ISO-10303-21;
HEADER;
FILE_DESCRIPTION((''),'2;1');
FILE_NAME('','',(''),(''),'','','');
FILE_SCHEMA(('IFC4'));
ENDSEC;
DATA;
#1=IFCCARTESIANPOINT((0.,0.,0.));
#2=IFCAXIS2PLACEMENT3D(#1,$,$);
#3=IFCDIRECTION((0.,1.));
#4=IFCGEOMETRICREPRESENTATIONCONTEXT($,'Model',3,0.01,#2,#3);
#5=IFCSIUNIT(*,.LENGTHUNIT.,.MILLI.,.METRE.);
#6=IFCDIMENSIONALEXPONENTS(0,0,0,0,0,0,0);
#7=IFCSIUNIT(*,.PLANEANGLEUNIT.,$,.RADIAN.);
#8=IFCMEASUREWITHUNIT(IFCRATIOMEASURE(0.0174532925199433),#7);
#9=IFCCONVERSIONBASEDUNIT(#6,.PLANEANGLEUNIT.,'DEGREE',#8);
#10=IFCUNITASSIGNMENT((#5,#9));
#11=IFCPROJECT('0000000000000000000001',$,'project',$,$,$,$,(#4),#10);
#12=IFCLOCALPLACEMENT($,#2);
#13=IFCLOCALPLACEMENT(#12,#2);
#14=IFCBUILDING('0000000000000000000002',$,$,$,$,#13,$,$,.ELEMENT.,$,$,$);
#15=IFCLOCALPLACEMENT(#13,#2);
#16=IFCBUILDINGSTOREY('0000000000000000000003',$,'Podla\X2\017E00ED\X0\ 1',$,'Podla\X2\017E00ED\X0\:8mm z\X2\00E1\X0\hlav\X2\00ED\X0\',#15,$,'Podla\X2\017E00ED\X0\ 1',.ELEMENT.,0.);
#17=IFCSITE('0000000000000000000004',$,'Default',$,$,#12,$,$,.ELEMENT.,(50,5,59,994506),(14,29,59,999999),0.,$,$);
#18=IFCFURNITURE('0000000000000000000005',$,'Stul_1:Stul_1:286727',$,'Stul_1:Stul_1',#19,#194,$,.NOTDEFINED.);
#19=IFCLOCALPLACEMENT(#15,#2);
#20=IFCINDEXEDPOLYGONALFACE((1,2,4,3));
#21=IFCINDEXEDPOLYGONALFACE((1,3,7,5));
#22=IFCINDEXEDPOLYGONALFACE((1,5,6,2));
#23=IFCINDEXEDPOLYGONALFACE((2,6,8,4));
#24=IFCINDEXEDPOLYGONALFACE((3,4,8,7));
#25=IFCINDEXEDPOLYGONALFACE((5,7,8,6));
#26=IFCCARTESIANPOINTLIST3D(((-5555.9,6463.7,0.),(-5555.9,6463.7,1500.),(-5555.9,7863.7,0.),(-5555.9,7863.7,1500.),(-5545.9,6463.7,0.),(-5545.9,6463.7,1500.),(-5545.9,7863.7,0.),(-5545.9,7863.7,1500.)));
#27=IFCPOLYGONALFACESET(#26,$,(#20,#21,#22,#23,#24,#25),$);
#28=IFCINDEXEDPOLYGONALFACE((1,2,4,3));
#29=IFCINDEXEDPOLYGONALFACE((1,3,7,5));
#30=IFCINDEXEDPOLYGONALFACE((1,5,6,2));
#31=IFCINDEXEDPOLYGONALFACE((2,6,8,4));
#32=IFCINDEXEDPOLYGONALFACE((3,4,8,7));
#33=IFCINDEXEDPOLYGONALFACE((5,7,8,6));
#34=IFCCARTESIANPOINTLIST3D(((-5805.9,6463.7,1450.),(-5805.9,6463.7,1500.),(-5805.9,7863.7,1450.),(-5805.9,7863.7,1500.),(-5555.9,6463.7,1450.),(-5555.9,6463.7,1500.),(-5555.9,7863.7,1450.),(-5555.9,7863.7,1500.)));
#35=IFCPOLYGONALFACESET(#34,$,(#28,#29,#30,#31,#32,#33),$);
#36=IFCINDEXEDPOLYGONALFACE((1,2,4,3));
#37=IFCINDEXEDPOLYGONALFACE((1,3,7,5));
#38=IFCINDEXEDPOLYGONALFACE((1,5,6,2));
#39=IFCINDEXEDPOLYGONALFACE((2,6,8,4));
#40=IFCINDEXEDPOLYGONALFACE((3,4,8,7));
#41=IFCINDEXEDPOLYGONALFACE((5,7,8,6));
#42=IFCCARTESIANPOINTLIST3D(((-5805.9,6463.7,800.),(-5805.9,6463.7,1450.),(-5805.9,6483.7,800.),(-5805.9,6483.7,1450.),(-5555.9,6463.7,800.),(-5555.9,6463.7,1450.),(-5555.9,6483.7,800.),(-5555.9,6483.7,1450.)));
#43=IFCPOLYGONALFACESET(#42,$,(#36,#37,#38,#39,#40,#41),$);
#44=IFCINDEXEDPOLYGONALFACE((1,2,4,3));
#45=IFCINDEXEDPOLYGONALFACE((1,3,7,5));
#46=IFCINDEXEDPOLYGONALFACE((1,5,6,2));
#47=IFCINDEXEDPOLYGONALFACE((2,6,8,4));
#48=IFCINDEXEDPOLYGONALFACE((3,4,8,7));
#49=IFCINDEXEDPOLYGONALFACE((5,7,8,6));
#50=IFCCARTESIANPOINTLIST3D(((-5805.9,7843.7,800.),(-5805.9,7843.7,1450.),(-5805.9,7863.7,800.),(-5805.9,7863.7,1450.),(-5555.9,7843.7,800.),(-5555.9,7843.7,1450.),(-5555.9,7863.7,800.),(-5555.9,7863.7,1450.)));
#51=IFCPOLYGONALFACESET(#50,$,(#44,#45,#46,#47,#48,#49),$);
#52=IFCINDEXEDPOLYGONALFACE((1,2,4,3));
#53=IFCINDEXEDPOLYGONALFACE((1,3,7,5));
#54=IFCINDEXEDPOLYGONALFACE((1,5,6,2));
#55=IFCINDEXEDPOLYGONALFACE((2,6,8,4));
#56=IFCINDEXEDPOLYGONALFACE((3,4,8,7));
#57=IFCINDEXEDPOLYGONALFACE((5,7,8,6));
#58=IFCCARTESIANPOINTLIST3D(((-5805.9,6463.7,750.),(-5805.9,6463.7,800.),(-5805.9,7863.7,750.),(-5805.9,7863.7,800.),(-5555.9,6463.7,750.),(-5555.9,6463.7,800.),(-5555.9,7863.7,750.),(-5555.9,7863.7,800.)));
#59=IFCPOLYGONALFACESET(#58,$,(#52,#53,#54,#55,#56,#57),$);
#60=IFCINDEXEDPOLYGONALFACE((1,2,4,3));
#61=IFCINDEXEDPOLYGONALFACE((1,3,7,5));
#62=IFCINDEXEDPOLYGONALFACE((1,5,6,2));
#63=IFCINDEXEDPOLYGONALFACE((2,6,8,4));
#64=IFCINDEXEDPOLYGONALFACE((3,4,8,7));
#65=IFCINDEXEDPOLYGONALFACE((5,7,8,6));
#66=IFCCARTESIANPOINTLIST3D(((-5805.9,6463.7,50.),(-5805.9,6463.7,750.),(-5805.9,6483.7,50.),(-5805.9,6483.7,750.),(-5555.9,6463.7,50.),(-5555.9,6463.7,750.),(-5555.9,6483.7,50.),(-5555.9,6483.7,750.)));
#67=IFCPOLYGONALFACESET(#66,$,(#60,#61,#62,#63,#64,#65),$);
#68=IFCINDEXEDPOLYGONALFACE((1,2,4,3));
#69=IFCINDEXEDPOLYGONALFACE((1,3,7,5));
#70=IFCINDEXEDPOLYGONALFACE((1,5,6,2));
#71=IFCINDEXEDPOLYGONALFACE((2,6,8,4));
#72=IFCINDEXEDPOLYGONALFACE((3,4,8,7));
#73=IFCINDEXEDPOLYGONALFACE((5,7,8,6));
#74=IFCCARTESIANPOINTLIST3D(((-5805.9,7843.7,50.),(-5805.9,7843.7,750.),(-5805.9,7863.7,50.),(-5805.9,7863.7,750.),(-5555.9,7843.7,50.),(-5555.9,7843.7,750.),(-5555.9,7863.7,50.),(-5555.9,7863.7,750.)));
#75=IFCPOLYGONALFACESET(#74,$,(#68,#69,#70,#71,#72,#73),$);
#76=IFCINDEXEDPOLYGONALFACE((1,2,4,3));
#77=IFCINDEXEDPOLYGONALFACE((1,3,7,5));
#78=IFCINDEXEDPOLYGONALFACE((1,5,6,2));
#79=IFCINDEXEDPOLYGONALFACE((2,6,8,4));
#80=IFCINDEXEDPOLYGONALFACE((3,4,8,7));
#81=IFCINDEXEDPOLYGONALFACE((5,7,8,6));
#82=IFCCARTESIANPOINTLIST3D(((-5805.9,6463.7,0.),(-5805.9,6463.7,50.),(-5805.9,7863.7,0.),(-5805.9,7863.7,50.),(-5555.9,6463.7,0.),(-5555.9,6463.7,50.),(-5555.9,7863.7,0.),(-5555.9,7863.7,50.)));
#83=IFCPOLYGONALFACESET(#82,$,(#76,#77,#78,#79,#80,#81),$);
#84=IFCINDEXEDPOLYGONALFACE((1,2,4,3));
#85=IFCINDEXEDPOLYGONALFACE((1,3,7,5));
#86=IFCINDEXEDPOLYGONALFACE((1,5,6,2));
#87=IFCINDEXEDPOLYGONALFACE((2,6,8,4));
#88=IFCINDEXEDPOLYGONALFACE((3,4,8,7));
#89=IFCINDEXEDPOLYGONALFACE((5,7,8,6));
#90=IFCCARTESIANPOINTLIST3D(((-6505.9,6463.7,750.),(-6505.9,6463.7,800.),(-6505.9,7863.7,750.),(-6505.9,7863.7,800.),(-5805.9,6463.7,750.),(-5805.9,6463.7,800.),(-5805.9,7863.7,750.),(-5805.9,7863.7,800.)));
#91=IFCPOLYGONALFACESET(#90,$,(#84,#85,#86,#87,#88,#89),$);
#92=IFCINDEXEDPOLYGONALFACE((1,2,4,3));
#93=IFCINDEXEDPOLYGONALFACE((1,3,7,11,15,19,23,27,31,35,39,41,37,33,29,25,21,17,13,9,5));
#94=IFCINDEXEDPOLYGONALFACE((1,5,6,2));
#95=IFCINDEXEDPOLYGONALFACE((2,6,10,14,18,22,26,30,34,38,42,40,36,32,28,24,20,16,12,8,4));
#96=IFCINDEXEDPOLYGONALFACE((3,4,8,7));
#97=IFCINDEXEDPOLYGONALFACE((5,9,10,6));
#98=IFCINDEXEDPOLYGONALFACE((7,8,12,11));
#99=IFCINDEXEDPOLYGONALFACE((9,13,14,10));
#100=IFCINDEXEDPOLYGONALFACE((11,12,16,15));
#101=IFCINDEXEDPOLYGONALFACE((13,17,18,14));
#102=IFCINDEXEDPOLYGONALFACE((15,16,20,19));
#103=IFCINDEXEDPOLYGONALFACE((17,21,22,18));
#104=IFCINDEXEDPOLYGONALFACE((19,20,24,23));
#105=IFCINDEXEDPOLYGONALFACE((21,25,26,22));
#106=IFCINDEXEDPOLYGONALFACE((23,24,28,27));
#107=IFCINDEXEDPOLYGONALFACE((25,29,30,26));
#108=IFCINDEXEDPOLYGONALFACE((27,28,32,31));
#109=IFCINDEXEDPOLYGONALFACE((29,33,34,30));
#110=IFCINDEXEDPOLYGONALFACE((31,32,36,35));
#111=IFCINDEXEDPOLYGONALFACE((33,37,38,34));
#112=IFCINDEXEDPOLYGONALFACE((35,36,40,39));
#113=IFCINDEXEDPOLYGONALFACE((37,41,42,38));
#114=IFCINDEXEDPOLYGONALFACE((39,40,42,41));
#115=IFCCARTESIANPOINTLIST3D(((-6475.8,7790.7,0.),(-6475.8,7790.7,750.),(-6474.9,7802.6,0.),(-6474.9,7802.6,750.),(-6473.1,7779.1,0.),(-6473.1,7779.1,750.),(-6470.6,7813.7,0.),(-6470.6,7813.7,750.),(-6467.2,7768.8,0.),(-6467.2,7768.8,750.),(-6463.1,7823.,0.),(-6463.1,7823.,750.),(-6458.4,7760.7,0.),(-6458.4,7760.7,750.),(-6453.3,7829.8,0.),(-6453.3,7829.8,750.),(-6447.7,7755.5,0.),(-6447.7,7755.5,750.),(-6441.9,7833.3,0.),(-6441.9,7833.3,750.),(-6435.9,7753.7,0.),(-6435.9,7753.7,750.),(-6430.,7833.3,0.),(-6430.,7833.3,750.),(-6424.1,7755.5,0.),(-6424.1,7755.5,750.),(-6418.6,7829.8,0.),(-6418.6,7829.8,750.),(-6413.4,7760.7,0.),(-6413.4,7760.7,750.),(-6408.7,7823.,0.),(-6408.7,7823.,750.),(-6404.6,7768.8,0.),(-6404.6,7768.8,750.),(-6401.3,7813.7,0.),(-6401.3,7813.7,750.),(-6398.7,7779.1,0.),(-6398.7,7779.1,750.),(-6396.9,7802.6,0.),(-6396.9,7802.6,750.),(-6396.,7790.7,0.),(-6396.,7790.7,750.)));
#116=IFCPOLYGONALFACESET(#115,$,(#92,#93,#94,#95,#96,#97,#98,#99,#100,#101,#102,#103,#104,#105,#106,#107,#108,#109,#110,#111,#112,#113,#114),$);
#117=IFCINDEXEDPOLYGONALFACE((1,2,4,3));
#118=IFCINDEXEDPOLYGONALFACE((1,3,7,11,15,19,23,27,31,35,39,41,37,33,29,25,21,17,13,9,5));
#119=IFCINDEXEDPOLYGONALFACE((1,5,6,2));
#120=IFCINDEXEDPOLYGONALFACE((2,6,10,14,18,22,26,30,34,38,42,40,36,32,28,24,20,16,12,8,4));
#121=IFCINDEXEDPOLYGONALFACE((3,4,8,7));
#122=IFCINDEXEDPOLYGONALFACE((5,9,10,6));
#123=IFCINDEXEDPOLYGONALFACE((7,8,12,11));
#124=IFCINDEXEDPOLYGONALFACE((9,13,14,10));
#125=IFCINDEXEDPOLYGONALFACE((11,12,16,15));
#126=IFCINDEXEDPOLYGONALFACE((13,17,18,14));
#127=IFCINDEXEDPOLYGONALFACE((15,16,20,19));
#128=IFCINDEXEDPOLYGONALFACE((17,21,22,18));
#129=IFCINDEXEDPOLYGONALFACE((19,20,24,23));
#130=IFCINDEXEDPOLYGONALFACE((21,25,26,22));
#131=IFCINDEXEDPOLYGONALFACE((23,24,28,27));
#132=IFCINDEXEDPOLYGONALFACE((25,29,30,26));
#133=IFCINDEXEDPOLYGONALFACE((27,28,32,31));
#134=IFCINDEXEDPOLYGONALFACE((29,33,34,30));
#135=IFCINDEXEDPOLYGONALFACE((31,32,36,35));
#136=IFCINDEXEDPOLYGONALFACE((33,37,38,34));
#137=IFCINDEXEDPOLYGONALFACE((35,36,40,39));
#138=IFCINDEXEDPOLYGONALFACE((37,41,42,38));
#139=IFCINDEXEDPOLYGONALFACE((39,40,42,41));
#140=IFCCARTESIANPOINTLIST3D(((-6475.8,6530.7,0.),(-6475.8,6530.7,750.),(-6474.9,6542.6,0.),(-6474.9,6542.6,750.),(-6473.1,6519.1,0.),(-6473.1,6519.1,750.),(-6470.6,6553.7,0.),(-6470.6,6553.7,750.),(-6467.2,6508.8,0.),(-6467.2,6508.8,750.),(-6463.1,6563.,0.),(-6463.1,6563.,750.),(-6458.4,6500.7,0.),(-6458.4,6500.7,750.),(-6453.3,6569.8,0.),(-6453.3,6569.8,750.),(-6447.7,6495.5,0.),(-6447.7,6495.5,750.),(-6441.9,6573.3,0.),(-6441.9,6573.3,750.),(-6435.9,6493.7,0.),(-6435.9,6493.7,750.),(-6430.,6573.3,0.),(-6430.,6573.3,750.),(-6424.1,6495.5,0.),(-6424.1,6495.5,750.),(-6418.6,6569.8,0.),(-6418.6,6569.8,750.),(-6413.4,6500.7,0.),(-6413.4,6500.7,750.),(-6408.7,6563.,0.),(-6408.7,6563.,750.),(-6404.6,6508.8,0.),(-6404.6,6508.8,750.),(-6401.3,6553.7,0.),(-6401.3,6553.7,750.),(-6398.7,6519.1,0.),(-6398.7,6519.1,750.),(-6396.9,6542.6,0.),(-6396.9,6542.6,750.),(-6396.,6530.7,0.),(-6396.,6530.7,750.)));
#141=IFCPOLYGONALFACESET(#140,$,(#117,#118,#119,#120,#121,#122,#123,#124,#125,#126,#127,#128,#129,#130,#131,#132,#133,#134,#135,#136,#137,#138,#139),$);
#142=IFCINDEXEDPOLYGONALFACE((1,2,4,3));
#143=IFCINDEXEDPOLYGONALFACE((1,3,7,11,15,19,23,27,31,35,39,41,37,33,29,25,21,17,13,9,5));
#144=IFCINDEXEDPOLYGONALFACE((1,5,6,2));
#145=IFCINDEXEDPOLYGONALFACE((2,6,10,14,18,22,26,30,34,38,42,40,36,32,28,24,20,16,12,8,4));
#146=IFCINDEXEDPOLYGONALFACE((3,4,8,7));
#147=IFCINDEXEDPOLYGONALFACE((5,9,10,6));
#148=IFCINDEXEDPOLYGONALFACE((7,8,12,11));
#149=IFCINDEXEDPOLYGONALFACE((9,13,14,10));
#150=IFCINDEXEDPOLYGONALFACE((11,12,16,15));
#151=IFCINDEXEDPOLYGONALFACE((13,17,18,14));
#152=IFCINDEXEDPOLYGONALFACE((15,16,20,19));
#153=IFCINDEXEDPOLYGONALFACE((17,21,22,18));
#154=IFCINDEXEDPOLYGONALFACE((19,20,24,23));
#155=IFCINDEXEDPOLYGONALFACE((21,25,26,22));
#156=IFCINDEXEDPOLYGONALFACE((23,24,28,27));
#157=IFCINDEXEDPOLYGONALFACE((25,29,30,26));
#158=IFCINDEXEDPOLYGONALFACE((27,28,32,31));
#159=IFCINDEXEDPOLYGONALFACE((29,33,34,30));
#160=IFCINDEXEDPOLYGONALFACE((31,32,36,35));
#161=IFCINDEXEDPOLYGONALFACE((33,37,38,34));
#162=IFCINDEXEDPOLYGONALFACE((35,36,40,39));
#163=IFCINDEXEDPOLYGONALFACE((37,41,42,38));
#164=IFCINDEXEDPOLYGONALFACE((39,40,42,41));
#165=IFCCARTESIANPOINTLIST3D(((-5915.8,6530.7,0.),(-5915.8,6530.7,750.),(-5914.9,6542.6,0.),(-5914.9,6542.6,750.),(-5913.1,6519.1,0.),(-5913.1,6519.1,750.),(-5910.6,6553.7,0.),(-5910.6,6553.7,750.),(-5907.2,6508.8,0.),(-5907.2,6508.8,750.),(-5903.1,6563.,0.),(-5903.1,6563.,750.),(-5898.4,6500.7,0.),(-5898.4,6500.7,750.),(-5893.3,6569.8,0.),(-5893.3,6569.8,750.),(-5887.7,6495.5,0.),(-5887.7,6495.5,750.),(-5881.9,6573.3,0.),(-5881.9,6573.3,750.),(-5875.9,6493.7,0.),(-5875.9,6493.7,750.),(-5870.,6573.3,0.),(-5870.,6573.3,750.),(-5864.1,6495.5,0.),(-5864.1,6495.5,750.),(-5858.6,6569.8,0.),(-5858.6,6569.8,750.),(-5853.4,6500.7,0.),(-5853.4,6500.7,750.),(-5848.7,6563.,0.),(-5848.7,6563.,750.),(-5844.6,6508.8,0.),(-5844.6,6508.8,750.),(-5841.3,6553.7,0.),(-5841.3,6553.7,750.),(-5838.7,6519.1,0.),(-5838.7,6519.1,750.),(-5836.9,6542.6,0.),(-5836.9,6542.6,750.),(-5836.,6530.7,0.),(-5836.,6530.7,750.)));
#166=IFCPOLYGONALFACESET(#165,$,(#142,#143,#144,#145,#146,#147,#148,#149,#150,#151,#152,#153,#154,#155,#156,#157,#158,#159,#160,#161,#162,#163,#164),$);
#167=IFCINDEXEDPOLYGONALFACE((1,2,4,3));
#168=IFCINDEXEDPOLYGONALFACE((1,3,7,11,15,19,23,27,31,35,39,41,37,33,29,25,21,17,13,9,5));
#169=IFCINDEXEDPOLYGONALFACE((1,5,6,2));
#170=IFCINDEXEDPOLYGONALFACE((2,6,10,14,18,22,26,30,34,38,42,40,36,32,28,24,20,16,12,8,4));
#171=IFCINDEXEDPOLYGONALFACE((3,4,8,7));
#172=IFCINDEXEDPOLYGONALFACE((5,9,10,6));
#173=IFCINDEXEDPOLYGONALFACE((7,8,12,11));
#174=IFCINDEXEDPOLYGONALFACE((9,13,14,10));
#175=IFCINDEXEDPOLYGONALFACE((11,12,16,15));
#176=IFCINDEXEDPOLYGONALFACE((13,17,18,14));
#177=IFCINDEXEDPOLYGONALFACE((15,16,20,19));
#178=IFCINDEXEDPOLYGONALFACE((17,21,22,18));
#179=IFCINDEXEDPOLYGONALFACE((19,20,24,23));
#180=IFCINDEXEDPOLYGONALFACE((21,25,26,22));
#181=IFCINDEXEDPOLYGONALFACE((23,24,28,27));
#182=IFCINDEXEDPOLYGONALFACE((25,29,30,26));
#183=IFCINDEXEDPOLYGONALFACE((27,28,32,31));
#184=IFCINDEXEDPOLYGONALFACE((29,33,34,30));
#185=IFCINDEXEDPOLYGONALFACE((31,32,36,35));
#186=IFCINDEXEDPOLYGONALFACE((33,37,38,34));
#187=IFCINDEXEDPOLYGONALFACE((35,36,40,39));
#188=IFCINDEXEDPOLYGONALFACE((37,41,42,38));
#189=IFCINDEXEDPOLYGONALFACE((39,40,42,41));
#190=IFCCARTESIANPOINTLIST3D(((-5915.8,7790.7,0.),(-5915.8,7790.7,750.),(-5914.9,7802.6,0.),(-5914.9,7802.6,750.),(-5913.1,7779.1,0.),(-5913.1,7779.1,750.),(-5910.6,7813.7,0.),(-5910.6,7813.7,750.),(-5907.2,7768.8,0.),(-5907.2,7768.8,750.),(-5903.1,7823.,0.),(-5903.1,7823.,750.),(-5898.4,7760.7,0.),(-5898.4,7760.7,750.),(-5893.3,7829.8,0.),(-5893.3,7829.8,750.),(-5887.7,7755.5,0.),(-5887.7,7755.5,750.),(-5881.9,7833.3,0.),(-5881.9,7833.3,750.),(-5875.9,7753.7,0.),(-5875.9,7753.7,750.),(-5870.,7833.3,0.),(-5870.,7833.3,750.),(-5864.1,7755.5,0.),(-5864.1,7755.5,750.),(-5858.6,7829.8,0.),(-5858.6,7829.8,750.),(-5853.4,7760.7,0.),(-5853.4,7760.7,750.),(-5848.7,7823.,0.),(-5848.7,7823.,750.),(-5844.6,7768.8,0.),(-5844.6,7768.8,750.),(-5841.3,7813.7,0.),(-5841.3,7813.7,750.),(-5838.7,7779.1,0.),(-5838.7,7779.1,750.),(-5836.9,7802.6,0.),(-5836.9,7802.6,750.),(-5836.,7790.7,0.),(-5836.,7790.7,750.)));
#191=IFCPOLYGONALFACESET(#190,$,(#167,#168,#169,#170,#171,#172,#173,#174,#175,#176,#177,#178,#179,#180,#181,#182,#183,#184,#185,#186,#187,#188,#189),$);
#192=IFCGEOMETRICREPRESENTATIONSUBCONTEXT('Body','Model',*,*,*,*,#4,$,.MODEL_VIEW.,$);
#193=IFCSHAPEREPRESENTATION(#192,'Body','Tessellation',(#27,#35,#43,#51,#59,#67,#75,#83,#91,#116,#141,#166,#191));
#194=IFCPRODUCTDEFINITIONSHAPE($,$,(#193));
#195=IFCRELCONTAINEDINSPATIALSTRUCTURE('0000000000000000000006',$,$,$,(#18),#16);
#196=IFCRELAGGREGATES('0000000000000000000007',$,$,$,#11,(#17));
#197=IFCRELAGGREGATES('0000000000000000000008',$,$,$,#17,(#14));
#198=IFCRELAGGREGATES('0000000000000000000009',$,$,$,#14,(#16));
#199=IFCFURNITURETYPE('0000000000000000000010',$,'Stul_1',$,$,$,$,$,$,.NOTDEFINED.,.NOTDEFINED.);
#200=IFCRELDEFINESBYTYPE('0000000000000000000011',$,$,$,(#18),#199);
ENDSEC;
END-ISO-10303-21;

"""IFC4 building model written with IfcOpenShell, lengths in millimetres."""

from ifc_helpers import new_model, entity, si_unit, converted_unit, direction, frame, frame_2d, origin, origin_2d_with_axis, place, context, subcontext, project, spatial, rectangle, circle, extrude, source, transform, mapped, type_object, type_shapes, element, save


model = new_model("IFC4")

# Units and contexts
model_context = context("Model", 3, precision=0.01, world=origin(), true_north=direction((0.0, 1.0)))
body_context = subcontext(model_context, "Body", "Model", "MODEL_VIEW")
ifc_project = project(units=[si_unit("LENGTHUNIT", "METRE", prefix="MILLI"), converted_unit("PLANEANGLEUNIT", "DEGREE", entity("IfcRatioMeasure", 0.0174532925199433), si_unit("PLANEANGLEUNIT", "RADIAN"), dimensions=[0, 0, 0, 0, 0, 0, 0])], contexts=[model_context])

# Site, building, storey
site_placement = place(None, origin())
site = spatial("IfcSite", under=ifc_project, at=site_placement, Name="Default", CompositionType="ELEMENT", RefLatitude=(50, 5, 59, 994506), RefLongitude=(14, 29, 59, 999999), RefElevation=0.0)
building_placement = place(site_placement, origin())
building = spatial("IfcBuilding", under=site, at=building_placement, CompositionType="ELEMENT")
storey_placement = place(building_placement, origin())
storey = spatial("IfcBuildingStorey", under=building, at=storey_placement, Name="Podlaží 1", ObjectType="Podlaží:8mm záhlaví", LongName="Podlaží 1", CompositionType="ELEMENT", Elevation=0.0)

# Furniture
furniture_type = type_object("IfcFurnitureType", Name="Stul_1", AssemblyPlace="NOTDEFINED", PredefinedType="NOTDEFINED")
shared_shape_1 = source(origin(), body_context, "Body", "SweptSolid", [
    extrude(rectangle(XDim=1400.0, YDim=10.0, at=origin_2d_with_axis()), frame((0.0, 605.0, 0.0), z_axis=(0.0, 0.0, 1.0), x_axis=(-1.0, 0.0, 0.0)), (0.0, 0.0, 1.0), 1500.0),
    extrude(rectangle(XDim=1400.0, YDim=250.0, at=frame_2d((0.0, 0.0), x_axis=(1.0, 0.0))), frame((0.0, 475.0, 1450.0), z_axis=(0.0, 0.0, 1.0), x_axis=(-1.0, 0.0, 0.0)), (0.0, 0.0, 1.0), 50.0),
    extrude(rectangle(XDim=20.0, YDim=250.0, at=origin_2d_with_axis()), frame((690.0, 475.0, 800.0), z_axis=(0.0, 0.0, 1.0), x_axis=(-1.0, 0.0, 0.0)), (0.0, 0.0, 1.0), 650.0),
    extrude(rectangle(XDim=20.0, YDim=250.0, at=frame_2d((0.0, 0.0), x_axis=(1.0, 0.0))), frame((-690.0, 475.0, 800.0), z_axis=(0.0, 0.0, 1.0), x_axis=(-1.0, 0.0, 0.0)), (0.0, 0.0, 1.0), 650.0),
    extrude(rectangle(XDim=1400.0, YDim=250.0, at=origin_2d_with_axis()), frame((0.0, 475.0, 750.0), z_axis=(0.0, 0.0, 1.0), x_axis=(-1.0, 0.0, 0.0)), (0.0, 0.0, 1.0), 50.0),
    extrude(rectangle(XDim=20.0, YDim=250.0, at=origin_2d_with_axis()), frame((690.0, 475.0, 50.0), z_axis=(0.0, 0.0, 1.0), x_axis=(-1.0, 0.0, 0.0)), (0.0, 0.0, 1.0), 700.0),
    extrude(rectangle(XDim=20.0, YDim=250.0, at=frame_2d((0.0, 0.0), x_axis=(1.0, 0.0))), frame((-690.0, 475.0, 50.0), z_axis=(0.0, 0.0, 1.0), x_axis=(-1.0, 0.0, 0.0)), (0.0, 0.0, 1.0), 700.0),
    extrude(rectangle(XDim=1400.0, YDim=250.0, at=origin_2d_with_axis()), frame((0.0, 475.0, 0.0), z_axis=(0.0, 0.0, 1.0), x_axis=(-1.0, 0.0, 0.0)), (0.0, 0.0, 1.0), 50.0),
    extrude(rectangle(XDim=1400.0, YDim=700.0, at=origin_2d_with_axis()), frame((0.0, 0.0, 750.0), z_axis=(0.0, 0.0, 1.0), x_axis=(-1.0, 0.0, 0.0)), (0.0, 0.0, 1.0), 50.0),
    extrude(circle(Radius=40.0, at=frame_2d((0.0, 0.0), x_axis=(1.0, 0.0))), frame((-630.0, -280.0, 0.0)), (0.0, 0.0, 1.0), 750.0),
    extrude(circle(Radius=40.0, at=frame_2d((0.0, 0.0), x_axis=(1.0, 0.0))), frame((630.0, -280.0, 0.0)), (0.0, 0.0, 1.0), 750.0),
    extrude(circle(Radius=40.0, at=frame_2d((0.0, 0.0), x_axis=(1.0, 0.0))), frame((630.0, 280.0, 0.0)), (0.0, 0.0, 1.0), 750.0),
    extrude(circle(Radius=40.0, at=frame_2d((0.0, 0.0), x_axis=(1.0, 0.0))), frame((-630.0, 280.0, 0.0)), (0.0, 0.0, 1.0), 750.0),
])
type_shapes(furniture_type, [shared_shape_1])
for number, where, z_axis, x_axis, name in (
    (1, (-6155.9, 7163.7, 0.0), (0.0, 0.0, 1.0), (0.0, -1.0, 0.0), "Stul_1:Stul_1:286727"),
):
    element("IfcFurniture", number, at=place(storey_placement, frame(where, z_axis=z_axis, x_axis=x_axis)), inside=storey, type_object=furniture_type, Name=name, ObjectType="Stul_1:Stul_1", PredefinedType="NOTDEFINED", context=body_context, shape_type="MappedRepresentation", body=[
        mapped(shared_shape_1, transform((0.0, 0.0, 0.0), scale=1.0)),
    ])

save(model, "model.ifc")
